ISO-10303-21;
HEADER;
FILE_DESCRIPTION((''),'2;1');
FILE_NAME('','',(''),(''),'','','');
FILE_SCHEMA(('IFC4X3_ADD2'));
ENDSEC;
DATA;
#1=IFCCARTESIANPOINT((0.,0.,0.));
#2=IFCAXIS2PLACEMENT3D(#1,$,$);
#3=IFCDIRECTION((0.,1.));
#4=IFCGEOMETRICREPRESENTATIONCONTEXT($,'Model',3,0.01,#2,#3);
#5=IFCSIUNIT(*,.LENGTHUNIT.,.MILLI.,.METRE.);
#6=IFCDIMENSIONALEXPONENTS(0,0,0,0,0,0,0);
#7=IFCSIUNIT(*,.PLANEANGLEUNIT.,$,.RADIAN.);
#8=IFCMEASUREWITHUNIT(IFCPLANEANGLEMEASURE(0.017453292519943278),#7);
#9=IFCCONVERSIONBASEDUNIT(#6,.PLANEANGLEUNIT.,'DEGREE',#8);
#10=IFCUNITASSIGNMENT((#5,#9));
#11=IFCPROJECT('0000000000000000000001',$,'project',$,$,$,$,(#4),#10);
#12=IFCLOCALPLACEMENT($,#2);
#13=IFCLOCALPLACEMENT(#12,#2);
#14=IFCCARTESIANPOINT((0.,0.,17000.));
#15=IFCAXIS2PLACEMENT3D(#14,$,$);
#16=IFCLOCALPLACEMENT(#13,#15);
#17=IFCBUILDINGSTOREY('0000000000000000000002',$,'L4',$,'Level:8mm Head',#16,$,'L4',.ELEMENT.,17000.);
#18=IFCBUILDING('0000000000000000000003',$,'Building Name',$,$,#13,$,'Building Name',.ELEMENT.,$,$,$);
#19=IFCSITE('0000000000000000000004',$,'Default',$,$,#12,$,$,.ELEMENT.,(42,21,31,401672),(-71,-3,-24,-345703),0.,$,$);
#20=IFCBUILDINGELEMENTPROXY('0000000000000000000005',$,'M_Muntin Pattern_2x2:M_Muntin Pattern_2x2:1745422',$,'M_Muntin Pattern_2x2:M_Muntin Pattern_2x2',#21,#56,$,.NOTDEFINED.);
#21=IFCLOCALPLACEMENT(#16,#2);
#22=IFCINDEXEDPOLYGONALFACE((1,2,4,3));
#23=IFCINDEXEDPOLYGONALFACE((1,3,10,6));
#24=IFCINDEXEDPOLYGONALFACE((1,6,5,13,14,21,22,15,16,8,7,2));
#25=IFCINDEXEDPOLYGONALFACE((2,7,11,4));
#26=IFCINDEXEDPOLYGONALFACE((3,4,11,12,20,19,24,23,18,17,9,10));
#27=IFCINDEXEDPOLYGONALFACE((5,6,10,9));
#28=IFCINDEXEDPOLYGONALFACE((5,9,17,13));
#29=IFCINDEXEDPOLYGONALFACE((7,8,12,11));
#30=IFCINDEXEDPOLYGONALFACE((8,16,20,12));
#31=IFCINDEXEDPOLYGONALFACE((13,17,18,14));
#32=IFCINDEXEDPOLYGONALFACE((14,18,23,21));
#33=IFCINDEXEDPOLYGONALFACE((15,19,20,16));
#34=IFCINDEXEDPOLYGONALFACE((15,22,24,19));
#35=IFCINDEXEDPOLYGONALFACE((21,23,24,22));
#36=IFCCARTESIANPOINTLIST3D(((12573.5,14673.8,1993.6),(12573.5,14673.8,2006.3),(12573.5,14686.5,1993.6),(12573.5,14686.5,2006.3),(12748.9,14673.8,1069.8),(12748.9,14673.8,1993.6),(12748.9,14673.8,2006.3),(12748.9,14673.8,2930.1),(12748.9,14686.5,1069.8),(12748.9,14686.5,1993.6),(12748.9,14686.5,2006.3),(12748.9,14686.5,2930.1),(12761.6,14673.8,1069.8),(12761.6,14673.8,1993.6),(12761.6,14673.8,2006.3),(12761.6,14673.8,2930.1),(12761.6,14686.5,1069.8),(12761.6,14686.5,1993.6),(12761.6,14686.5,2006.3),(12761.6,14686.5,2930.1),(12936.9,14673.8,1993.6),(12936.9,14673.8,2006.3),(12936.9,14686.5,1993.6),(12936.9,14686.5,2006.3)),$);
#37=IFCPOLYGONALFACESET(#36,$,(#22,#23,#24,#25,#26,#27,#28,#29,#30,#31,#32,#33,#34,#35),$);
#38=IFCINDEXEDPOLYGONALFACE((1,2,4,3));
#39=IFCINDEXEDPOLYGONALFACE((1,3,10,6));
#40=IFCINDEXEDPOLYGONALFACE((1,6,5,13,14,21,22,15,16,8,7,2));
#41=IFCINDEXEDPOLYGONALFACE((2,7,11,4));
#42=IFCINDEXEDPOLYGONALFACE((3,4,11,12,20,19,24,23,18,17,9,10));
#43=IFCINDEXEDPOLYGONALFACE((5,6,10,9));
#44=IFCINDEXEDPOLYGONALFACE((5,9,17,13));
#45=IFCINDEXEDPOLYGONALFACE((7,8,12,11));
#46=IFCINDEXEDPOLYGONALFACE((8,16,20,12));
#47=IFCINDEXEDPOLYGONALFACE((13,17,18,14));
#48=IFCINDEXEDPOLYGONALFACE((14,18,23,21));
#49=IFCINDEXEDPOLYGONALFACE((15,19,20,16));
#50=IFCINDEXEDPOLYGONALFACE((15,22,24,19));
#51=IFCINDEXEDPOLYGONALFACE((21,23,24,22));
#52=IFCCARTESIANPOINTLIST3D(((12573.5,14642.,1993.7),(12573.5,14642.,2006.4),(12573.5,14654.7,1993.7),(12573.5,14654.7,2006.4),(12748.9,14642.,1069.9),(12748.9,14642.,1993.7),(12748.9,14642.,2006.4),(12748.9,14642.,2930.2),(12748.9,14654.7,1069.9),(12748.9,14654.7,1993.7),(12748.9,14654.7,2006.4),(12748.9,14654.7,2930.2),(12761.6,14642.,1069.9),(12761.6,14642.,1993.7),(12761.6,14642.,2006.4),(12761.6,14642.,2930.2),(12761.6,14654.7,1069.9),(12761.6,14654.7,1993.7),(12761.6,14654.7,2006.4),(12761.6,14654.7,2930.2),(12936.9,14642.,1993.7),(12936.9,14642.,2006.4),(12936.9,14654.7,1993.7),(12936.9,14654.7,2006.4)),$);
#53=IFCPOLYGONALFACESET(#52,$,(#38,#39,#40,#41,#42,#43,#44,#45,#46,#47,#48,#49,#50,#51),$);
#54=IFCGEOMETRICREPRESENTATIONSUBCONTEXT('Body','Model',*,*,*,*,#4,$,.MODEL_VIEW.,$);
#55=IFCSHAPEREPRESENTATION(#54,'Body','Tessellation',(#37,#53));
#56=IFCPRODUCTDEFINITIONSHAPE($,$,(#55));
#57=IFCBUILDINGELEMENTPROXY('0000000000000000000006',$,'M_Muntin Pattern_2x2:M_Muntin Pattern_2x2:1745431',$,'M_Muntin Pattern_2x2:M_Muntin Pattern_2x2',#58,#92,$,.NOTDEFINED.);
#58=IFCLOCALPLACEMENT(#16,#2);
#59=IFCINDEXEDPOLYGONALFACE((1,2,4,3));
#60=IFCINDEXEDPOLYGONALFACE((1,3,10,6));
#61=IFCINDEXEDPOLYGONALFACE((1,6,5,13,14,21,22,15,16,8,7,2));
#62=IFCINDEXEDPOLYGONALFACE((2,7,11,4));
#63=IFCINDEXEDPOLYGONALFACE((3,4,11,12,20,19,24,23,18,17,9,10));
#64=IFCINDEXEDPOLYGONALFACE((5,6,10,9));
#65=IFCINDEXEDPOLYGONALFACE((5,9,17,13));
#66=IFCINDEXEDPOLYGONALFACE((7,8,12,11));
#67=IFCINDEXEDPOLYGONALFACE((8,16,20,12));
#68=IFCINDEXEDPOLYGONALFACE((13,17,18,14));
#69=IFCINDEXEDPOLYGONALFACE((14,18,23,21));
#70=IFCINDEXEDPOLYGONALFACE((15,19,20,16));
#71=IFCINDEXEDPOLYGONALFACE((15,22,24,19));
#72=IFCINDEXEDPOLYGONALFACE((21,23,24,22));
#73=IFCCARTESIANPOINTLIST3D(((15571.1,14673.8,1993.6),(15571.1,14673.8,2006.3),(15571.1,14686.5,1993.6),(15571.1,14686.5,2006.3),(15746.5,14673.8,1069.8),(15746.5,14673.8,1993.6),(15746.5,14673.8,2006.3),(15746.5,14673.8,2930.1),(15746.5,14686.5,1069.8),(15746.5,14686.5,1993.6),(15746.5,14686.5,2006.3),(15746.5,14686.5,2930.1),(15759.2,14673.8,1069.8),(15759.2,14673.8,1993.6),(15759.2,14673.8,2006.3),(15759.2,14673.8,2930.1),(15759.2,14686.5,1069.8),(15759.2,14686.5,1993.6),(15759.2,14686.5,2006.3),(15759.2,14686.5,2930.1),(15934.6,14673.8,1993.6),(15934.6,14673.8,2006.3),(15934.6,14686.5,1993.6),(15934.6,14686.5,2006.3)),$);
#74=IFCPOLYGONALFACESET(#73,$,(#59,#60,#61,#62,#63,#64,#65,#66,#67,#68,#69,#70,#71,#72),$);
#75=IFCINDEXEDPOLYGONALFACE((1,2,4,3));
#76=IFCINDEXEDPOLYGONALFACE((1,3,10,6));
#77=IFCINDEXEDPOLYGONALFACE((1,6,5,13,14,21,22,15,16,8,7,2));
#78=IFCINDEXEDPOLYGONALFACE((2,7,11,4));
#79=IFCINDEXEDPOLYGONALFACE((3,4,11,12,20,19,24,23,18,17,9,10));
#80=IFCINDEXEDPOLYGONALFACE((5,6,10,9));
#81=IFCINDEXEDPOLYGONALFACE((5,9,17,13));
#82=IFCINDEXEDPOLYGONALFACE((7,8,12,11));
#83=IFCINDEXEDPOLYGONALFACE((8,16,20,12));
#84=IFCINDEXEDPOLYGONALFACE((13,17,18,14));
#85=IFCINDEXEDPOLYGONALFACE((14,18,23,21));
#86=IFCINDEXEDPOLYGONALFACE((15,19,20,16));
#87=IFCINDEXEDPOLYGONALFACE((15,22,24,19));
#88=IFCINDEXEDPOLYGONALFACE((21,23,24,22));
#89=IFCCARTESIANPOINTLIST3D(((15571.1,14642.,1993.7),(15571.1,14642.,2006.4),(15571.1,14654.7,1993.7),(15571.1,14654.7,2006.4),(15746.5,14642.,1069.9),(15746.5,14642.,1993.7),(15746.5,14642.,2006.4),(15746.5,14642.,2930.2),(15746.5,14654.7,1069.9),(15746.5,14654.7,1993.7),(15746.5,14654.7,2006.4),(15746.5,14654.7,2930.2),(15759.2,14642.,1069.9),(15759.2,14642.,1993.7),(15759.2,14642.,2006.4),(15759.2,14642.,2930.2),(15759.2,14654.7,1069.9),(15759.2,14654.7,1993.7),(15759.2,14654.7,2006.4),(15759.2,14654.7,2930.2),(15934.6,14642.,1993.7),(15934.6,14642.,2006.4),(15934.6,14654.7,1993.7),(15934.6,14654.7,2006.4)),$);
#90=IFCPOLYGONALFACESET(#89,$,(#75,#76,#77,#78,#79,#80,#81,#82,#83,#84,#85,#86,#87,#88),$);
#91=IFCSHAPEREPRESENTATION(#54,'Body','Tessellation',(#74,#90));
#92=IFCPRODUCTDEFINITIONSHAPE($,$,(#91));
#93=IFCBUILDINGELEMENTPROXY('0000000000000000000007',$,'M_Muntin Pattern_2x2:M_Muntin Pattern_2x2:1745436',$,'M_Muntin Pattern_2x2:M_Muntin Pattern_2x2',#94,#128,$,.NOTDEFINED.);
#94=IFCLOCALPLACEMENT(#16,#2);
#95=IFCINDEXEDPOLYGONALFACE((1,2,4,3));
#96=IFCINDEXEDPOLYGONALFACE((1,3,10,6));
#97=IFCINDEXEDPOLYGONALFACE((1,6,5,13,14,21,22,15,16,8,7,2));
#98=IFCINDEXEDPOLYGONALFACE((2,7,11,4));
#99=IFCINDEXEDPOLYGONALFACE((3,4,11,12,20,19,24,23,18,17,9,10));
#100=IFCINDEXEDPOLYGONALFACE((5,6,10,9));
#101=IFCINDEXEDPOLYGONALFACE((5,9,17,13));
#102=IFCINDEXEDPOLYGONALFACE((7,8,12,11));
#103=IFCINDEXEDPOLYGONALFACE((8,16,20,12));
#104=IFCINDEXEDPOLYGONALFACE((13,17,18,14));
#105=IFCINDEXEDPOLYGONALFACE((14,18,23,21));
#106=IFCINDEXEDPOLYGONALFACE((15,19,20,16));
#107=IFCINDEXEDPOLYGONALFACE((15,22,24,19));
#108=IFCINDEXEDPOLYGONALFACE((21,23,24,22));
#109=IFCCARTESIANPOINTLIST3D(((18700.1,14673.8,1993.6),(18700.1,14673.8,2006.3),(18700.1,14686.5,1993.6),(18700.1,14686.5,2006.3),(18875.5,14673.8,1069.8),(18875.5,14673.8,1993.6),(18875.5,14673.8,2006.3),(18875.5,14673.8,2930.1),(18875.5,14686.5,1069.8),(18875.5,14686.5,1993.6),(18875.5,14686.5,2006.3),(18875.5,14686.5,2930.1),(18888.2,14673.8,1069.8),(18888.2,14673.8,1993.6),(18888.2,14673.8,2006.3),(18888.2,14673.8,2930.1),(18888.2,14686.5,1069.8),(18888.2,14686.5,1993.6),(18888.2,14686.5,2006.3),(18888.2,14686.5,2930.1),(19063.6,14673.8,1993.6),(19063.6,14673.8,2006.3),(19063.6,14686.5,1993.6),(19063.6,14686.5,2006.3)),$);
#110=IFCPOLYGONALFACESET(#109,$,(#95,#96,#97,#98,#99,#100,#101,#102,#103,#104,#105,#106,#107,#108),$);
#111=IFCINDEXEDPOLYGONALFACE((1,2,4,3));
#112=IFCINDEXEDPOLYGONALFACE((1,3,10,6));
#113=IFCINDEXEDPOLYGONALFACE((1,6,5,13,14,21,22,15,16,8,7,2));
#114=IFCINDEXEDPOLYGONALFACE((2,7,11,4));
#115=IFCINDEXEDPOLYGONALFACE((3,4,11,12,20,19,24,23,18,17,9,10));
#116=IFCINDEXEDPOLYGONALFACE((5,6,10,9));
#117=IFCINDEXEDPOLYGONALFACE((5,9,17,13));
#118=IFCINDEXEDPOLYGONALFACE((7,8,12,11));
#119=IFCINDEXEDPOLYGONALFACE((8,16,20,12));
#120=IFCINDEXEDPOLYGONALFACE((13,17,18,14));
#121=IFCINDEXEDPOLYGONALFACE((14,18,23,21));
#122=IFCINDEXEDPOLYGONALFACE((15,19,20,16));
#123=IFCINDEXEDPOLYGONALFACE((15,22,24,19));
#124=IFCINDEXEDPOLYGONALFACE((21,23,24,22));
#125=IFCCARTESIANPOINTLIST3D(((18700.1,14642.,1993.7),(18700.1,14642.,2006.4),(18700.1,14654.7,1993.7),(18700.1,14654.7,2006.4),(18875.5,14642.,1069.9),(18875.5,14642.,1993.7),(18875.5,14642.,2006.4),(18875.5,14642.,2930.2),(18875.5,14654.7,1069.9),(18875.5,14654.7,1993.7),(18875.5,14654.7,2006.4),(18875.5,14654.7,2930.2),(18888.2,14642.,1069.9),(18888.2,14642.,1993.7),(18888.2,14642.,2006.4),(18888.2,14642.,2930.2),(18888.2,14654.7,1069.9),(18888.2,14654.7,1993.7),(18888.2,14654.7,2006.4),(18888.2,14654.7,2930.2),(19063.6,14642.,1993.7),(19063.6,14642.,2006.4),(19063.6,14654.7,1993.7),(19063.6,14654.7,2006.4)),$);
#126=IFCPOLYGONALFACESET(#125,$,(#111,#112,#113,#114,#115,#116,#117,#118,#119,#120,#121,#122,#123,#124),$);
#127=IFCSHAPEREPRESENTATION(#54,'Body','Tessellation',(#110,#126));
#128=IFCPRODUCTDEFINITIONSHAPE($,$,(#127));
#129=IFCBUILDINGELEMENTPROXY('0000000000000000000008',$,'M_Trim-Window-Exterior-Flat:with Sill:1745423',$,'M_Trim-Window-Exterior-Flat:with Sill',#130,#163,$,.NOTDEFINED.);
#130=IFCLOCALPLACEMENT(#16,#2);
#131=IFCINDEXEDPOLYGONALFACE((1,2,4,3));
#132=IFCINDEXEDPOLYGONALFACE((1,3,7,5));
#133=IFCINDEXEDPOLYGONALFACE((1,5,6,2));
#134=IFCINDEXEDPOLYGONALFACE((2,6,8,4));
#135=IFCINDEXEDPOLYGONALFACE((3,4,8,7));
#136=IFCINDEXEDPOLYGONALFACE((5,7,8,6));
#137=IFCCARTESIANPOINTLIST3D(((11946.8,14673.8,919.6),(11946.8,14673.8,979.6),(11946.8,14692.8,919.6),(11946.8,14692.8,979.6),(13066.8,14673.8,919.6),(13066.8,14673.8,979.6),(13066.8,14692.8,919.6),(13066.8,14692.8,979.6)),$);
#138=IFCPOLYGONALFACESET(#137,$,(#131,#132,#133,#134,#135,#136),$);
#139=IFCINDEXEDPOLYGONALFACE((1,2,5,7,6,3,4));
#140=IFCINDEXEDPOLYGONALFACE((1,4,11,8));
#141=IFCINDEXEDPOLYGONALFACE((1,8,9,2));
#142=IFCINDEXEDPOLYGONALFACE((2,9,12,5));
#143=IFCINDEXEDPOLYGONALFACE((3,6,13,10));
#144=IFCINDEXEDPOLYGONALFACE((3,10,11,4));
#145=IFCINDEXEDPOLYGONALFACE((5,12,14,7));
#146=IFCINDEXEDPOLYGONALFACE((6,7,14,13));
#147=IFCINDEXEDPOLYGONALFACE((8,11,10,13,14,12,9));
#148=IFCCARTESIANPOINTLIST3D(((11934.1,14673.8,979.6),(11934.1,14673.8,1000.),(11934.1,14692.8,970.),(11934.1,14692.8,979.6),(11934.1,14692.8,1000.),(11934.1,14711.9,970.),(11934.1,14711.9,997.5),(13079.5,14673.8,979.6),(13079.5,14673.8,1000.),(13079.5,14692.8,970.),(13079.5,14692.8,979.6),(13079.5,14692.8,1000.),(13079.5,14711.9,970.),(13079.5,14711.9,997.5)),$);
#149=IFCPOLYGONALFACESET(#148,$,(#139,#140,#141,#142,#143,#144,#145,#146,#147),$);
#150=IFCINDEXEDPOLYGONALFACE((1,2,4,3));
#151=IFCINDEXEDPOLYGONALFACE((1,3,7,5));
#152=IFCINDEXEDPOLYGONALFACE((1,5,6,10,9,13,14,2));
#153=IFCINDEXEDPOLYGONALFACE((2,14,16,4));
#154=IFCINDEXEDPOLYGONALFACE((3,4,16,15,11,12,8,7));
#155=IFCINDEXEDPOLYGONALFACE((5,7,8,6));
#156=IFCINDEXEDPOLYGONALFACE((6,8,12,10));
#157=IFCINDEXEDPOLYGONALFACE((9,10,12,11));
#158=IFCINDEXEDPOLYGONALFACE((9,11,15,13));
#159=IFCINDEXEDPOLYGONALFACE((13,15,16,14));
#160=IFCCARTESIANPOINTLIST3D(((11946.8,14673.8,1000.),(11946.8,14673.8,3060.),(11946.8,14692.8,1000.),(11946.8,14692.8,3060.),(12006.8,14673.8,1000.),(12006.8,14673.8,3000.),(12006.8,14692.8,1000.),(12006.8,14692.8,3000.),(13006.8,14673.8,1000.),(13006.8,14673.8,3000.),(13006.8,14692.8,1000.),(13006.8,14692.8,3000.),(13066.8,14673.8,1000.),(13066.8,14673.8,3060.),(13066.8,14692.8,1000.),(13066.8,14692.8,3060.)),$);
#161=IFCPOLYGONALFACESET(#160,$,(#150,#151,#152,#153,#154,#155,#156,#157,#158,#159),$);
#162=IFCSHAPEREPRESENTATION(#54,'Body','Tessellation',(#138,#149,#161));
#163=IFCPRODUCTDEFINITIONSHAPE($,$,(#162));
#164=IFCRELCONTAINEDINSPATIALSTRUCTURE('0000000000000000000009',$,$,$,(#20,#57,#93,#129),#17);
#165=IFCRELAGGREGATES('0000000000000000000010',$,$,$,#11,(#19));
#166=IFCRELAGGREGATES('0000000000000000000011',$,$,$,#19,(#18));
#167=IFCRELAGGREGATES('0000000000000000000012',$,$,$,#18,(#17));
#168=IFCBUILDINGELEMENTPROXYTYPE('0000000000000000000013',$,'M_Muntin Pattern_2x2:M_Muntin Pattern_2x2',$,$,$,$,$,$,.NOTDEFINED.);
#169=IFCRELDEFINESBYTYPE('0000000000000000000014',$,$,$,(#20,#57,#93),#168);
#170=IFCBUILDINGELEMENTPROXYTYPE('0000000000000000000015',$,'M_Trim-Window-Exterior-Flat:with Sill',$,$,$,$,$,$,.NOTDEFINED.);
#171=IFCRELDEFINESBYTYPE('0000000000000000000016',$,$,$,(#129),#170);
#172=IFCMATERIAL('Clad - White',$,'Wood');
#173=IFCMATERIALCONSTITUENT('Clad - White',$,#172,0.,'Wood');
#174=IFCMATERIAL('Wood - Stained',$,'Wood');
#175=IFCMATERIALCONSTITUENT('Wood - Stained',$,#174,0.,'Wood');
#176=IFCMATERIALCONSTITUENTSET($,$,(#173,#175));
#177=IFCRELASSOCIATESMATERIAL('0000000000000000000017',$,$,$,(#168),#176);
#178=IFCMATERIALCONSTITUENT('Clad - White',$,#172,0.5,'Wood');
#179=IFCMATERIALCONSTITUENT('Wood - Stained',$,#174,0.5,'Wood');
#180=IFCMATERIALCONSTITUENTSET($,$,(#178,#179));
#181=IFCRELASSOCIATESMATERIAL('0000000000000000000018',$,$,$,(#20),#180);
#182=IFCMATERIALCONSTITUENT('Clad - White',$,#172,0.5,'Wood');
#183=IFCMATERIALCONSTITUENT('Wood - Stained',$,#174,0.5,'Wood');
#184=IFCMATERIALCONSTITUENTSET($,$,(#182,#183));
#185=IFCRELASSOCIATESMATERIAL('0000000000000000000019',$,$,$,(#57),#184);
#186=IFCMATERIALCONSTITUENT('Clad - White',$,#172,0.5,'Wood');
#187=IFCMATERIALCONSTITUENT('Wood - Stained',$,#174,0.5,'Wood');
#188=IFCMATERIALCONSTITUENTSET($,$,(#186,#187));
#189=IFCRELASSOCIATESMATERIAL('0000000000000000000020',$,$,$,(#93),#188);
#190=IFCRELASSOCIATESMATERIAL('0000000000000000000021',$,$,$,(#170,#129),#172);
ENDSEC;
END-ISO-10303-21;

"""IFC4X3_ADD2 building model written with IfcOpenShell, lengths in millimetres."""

from ifc_helpers import new_model, entity, si_unit, converted_unit, direction, frame, frame_2d, origin, place, context, subcontext, project, spatial, polyline, rectangle, outline, extrude, source, transform, mapped, material, constituent, constituent_set, type_object, type_shapes, element, save


model = new_model("IFC4X3_ADD2")

# Units and contexts
model_context = context("Model", 3, precision=0.01, world=origin(), true_north=direction((0.0, 1.0)))
body_context = subcontext(model_context, "Body", "Model", "MODEL_VIEW")
ifc_project = project(units=[si_unit("LENGTHUNIT", "METRE", prefix="MILLI"), converted_unit("PLANEANGLEUNIT", "DEGREE", entity("IfcPlaneAngleMeasure", 0.017453292519943278), si_unit("PLANEANGLEUNIT", "RADIAN"), dimensions=[0, 0, 0, 0, 0, 0, 0])], contexts=[model_context])

# Site, building, storey
site_placement = place(None, origin())
site = spatial("IfcSite", under=ifc_project, at=site_placement, Name="Default", CompositionType="ELEMENT", RefLatitude=(42, 21, 31, 401672), RefLongitude=(-71, -3, -24, -345703), RefElevation=0.0)
building_placement = place(site_placement, origin())
building = spatial("IfcBuilding", under=site, at=building_placement, Name="Building Name", LongName="Building Name", CompositionType="ELEMENT")
storey_placement = place(building_placement, frame((0.0, 0.0, 17000.0)))
storey = spatial("IfcBuildingStorey", under=building, at=storey_placement, Name="L4", ObjectType="Level:8mm Head", LongName="L4", CompositionType="ELEMENT", Elevation=17000.0)

# Building element proxies
ifc_material_1 = material(Name="Clad - White", Category="Wood")
ifc_material_2 = material(Name="Wood - Stained", Category="Wood")
ifc_constituent_1 = constituent(ifc_material_1, Name="Clad - White", Category="Wood", fraction=0.5)
ifc_constituent_2 = constituent(ifc_material_2, Name="Wood - Stained", Category="Wood", fraction=0.5)
ifc_constituent_set_1 = constituent_set(constituents=[ifc_constituent_1, ifc_constituent_2])
ifc_constituent_3 = constituent(ifc_material_1, Name="Clad - White", Category="Wood", fraction=0.0)
ifc_constituent_4 = constituent(ifc_material_2, Name="Wood - Stained", Category="Wood", fraction=0.0)
ifc_constituent_set_2 = constituent_set(constituents=[ifc_constituent_3, ifc_constituent_4])
building_element_proxy_type_1 = type_object("IfcBuildingElementProxyType", Name="M_Muntin Pattern_2x2:M_Muntin Pattern_2x2", PredefinedType="NOTDEFINED", material=ifc_constituent_set_2)
shared_shape_1 = source(origin(), body_context, "Body", "SweptSolid", [
    extrude(outline(polyline([(6.4, -6.4), (930.1, -6.4), (930.1, 6.3), (6.4, 6.3), (6.4, 181.7), (-6.3, 181.7), (-6.3, 6.3), (-930.2, 6.3), (-930.2, -6.4), (-6.3, -6.4), (-6.3, -181.7), (6.4, -181.7), (6.4, -6.4)])), frame((0.0, -22.2, 930.1), z_axis=(0.0, 1.0, 0.0), x_axis=(0.0, 0.0, 1.0)), (0.0, 0.0, 1.0), 12.7),
    extrude(outline(polyline([(6.4, -6.4), (930.2, -6.4), (930.2, 6.3), (6.4, 6.3), (6.4, 181.7), (-6.3, 181.7), (-6.3, 6.3), (-930.2, 6.3), (-930.2, -6.4), (-6.3, -6.4), (-6.3, -181.7), (6.4, -181.7), (6.4, -6.4)])), frame((0.0, 9.5, 930.2), z_axis=(0.0, 1.0, 0.0), x_axis=(0.0, 0.0, 1.0)), (0.0, 0.0, 1.0), 12.7),
])
type_shapes(building_element_proxy_type_1, [shared_shape_1])
proxy_1_placement = place(storey_placement, frame((12755.2, 14664.3, 1069.9), z_axis=(0.0, 0.0, 1.0), x_axis=(-1.0, 0.0, 0.0)))
element("IfcBuildingElementProxy", 1, at=proxy_1_placement, inside=storey, type_object=building_element_proxy_type_1, material=ifc_constituent_set_1, Name="M_Muntin Pattern_2x2:M_Muntin Pattern_2x2:1745422", ObjectType="M_Muntin Pattern_2x2:M_Muntin Pattern_2x2", PredefinedType="NOTDEFINED", context=body_context, shape_type="MappedRepresentation", body=[
    mapped(shared_shape_1, transform((0.0, 0.0, 0.0), scale=1.0)),
])
ifc_constituent_5 = constituent(ifc_material_1, Name="Clad - White", Category="Wood", fraction=0.5)
ifc_constituent_6 = constituent(ifc_material_2, Name="Wood - Stained", Category="Wood", fraction=0.5)
ifc_constituent_set_3 = constituent_set(constituents=[ifc_constituent_5, ifc_constituent_6])
proxy_2_placement = place(storey_placement, frame((15752.8, 14664.3, 1069.9), z_axis=(0.0, 0.0, 1.0), x_axis=(-1.0, 0.0, 0.0)))
element("IfcBuildingElementProxy", 2, at=proxy_2_placement, inside=storey, type_object=building_element_proxy_type_1, material=ifc_constituent_set_3, Name="M_Muntin Pattern_2x2:M_Muntin Pattern_2x2:1745431", ObjectType="M_Muntin Pattern_2x2:M_Muntin Pattern_2x2", PredefinedType="NOTDEFINED", context=body_context, shape_type="MappedRepresentation", body=[
    mapped(shared_shape_1, transform((0.0, 0.0, 0.0), scale=1.0)),
])
ifc_constituent_7 = constituent(ifc_material_1, Name="Clad - White", Category="Wood", fraction=0.5)
ifc_constituent_8 = constituent(ifc_material_2, Name="Wood - Stained", Category="Wood", fraction=0.5)
ifc_constituent_set_4 = constituent_set(constituents=[ifc_constituent_7, ifc_constituent_8])
proxy_3_placement = place(storey_placement, frame((18881.8, 14664.3, 1069.9), z_axis=(0.0, 0.0, 1.0), x_axis=(-1.0, 0.0, 0.0)))
element("IfcBuildingElementProxy", 3, at=proxy_3_placement, inside=storey, type_object=building_element_proxy_type_1, material=ifc_constituent_set_4, Name="M_Muntin Pattern_2x2:M_Muntin Pattern_2x2:1745436", ObjectType="M_Muntin Pattern_2x2:M_Muntin Pattern_2x2", PredefinedType="NOTDEFINED", context=body_context, shape_type="MappedRepresentation", body=[
    mapped(shared_shape_1, transform((0.0, 0.0, 0.0), scale=1.0)),
])
building_element_proxy_type_2 = type_object("IfcBuildingElementProxyType", Name="M_Trim-Window-Exterior-Flat:with Sill", PredefinedType="NOTDEFINED", material=ifc_material_1)
shared_shape_2 = source(origin(), body_context, "Body", "SweptSolid", [
    extrude(rectangle(XDim=1120.0, YDim=60.0, at=frame_2d((0.0, 0.0), x_axis=(1.0, 0.0))), frame((0.0, -2050.4, 0.0), z_axis=(0.0, 0.0, 1.0), x_axis=(-1.0, 0.0, 0.0)), (0.0, 0.0, 1.0), 19.0),
    extrude(outline(polyline([(-19.0, -15.2), (0.0, -15.2), (0.0, -5.7), (19.0, -5.7), (19.0, 14.8), (0.0, 14.8), (-19.0, 12.3), (-19.0, -15.2)])), frame((-572.7, -2014.8, 19.0), z_axis=(1.0, 0.0, 0.0), x_axis=(0.0, 0.0, -1.0)), (0.0, 0.0, 1.0), 1145.4),
    extrude(outline(polyline([(-1045.0, -560.0), (1015.0, -560.0), (1015.0, -500.0), (-985.0, -500.0), (-985.0, 500.0), (1015.0, 500.0), (1015.0, 560.0), (-1045.0, 560.0), (-1045.0, -560.0)])), frame((0.0, -985.0, 0.0), z_axis=(0.0, 0.0, 1.0), x_axis=(0.0, -1.0, 0.0)), (0.0, 0.0, 1.0), 19.0),
])
type_shapes(building_element_proxy_type_2, [shared_shape_2])
for number, where, z_axis, x_axis, name in (
    (4, (12506.8, 14673.8, 3000.0), (0.0, 1.0, 0.0), (-1.0, 0.0, 0.0), "M_Trim-Window-Exterior-Flat:with Sill:1745423"),
):
    element("IfcBuildingElementProxy", number, at=place(storey_placement, frame(where, z_axis=z_axis, x_axis=x_axis)), inside=storey, type_object=building_element_proxy_type_2, material=ifc_material_1, Name=name, ObjectType="M_Trim-Window-Exterior-Flat:with Sill", PredefinedType="NOTDEFINED", context=body_context, shape_type="MappedRepresentation", body=[
        mapped(shared_shape_2, transform((0.0, 0.0, 0.0), scale=1.0)),
    ])

save(model, "model.ifc")
